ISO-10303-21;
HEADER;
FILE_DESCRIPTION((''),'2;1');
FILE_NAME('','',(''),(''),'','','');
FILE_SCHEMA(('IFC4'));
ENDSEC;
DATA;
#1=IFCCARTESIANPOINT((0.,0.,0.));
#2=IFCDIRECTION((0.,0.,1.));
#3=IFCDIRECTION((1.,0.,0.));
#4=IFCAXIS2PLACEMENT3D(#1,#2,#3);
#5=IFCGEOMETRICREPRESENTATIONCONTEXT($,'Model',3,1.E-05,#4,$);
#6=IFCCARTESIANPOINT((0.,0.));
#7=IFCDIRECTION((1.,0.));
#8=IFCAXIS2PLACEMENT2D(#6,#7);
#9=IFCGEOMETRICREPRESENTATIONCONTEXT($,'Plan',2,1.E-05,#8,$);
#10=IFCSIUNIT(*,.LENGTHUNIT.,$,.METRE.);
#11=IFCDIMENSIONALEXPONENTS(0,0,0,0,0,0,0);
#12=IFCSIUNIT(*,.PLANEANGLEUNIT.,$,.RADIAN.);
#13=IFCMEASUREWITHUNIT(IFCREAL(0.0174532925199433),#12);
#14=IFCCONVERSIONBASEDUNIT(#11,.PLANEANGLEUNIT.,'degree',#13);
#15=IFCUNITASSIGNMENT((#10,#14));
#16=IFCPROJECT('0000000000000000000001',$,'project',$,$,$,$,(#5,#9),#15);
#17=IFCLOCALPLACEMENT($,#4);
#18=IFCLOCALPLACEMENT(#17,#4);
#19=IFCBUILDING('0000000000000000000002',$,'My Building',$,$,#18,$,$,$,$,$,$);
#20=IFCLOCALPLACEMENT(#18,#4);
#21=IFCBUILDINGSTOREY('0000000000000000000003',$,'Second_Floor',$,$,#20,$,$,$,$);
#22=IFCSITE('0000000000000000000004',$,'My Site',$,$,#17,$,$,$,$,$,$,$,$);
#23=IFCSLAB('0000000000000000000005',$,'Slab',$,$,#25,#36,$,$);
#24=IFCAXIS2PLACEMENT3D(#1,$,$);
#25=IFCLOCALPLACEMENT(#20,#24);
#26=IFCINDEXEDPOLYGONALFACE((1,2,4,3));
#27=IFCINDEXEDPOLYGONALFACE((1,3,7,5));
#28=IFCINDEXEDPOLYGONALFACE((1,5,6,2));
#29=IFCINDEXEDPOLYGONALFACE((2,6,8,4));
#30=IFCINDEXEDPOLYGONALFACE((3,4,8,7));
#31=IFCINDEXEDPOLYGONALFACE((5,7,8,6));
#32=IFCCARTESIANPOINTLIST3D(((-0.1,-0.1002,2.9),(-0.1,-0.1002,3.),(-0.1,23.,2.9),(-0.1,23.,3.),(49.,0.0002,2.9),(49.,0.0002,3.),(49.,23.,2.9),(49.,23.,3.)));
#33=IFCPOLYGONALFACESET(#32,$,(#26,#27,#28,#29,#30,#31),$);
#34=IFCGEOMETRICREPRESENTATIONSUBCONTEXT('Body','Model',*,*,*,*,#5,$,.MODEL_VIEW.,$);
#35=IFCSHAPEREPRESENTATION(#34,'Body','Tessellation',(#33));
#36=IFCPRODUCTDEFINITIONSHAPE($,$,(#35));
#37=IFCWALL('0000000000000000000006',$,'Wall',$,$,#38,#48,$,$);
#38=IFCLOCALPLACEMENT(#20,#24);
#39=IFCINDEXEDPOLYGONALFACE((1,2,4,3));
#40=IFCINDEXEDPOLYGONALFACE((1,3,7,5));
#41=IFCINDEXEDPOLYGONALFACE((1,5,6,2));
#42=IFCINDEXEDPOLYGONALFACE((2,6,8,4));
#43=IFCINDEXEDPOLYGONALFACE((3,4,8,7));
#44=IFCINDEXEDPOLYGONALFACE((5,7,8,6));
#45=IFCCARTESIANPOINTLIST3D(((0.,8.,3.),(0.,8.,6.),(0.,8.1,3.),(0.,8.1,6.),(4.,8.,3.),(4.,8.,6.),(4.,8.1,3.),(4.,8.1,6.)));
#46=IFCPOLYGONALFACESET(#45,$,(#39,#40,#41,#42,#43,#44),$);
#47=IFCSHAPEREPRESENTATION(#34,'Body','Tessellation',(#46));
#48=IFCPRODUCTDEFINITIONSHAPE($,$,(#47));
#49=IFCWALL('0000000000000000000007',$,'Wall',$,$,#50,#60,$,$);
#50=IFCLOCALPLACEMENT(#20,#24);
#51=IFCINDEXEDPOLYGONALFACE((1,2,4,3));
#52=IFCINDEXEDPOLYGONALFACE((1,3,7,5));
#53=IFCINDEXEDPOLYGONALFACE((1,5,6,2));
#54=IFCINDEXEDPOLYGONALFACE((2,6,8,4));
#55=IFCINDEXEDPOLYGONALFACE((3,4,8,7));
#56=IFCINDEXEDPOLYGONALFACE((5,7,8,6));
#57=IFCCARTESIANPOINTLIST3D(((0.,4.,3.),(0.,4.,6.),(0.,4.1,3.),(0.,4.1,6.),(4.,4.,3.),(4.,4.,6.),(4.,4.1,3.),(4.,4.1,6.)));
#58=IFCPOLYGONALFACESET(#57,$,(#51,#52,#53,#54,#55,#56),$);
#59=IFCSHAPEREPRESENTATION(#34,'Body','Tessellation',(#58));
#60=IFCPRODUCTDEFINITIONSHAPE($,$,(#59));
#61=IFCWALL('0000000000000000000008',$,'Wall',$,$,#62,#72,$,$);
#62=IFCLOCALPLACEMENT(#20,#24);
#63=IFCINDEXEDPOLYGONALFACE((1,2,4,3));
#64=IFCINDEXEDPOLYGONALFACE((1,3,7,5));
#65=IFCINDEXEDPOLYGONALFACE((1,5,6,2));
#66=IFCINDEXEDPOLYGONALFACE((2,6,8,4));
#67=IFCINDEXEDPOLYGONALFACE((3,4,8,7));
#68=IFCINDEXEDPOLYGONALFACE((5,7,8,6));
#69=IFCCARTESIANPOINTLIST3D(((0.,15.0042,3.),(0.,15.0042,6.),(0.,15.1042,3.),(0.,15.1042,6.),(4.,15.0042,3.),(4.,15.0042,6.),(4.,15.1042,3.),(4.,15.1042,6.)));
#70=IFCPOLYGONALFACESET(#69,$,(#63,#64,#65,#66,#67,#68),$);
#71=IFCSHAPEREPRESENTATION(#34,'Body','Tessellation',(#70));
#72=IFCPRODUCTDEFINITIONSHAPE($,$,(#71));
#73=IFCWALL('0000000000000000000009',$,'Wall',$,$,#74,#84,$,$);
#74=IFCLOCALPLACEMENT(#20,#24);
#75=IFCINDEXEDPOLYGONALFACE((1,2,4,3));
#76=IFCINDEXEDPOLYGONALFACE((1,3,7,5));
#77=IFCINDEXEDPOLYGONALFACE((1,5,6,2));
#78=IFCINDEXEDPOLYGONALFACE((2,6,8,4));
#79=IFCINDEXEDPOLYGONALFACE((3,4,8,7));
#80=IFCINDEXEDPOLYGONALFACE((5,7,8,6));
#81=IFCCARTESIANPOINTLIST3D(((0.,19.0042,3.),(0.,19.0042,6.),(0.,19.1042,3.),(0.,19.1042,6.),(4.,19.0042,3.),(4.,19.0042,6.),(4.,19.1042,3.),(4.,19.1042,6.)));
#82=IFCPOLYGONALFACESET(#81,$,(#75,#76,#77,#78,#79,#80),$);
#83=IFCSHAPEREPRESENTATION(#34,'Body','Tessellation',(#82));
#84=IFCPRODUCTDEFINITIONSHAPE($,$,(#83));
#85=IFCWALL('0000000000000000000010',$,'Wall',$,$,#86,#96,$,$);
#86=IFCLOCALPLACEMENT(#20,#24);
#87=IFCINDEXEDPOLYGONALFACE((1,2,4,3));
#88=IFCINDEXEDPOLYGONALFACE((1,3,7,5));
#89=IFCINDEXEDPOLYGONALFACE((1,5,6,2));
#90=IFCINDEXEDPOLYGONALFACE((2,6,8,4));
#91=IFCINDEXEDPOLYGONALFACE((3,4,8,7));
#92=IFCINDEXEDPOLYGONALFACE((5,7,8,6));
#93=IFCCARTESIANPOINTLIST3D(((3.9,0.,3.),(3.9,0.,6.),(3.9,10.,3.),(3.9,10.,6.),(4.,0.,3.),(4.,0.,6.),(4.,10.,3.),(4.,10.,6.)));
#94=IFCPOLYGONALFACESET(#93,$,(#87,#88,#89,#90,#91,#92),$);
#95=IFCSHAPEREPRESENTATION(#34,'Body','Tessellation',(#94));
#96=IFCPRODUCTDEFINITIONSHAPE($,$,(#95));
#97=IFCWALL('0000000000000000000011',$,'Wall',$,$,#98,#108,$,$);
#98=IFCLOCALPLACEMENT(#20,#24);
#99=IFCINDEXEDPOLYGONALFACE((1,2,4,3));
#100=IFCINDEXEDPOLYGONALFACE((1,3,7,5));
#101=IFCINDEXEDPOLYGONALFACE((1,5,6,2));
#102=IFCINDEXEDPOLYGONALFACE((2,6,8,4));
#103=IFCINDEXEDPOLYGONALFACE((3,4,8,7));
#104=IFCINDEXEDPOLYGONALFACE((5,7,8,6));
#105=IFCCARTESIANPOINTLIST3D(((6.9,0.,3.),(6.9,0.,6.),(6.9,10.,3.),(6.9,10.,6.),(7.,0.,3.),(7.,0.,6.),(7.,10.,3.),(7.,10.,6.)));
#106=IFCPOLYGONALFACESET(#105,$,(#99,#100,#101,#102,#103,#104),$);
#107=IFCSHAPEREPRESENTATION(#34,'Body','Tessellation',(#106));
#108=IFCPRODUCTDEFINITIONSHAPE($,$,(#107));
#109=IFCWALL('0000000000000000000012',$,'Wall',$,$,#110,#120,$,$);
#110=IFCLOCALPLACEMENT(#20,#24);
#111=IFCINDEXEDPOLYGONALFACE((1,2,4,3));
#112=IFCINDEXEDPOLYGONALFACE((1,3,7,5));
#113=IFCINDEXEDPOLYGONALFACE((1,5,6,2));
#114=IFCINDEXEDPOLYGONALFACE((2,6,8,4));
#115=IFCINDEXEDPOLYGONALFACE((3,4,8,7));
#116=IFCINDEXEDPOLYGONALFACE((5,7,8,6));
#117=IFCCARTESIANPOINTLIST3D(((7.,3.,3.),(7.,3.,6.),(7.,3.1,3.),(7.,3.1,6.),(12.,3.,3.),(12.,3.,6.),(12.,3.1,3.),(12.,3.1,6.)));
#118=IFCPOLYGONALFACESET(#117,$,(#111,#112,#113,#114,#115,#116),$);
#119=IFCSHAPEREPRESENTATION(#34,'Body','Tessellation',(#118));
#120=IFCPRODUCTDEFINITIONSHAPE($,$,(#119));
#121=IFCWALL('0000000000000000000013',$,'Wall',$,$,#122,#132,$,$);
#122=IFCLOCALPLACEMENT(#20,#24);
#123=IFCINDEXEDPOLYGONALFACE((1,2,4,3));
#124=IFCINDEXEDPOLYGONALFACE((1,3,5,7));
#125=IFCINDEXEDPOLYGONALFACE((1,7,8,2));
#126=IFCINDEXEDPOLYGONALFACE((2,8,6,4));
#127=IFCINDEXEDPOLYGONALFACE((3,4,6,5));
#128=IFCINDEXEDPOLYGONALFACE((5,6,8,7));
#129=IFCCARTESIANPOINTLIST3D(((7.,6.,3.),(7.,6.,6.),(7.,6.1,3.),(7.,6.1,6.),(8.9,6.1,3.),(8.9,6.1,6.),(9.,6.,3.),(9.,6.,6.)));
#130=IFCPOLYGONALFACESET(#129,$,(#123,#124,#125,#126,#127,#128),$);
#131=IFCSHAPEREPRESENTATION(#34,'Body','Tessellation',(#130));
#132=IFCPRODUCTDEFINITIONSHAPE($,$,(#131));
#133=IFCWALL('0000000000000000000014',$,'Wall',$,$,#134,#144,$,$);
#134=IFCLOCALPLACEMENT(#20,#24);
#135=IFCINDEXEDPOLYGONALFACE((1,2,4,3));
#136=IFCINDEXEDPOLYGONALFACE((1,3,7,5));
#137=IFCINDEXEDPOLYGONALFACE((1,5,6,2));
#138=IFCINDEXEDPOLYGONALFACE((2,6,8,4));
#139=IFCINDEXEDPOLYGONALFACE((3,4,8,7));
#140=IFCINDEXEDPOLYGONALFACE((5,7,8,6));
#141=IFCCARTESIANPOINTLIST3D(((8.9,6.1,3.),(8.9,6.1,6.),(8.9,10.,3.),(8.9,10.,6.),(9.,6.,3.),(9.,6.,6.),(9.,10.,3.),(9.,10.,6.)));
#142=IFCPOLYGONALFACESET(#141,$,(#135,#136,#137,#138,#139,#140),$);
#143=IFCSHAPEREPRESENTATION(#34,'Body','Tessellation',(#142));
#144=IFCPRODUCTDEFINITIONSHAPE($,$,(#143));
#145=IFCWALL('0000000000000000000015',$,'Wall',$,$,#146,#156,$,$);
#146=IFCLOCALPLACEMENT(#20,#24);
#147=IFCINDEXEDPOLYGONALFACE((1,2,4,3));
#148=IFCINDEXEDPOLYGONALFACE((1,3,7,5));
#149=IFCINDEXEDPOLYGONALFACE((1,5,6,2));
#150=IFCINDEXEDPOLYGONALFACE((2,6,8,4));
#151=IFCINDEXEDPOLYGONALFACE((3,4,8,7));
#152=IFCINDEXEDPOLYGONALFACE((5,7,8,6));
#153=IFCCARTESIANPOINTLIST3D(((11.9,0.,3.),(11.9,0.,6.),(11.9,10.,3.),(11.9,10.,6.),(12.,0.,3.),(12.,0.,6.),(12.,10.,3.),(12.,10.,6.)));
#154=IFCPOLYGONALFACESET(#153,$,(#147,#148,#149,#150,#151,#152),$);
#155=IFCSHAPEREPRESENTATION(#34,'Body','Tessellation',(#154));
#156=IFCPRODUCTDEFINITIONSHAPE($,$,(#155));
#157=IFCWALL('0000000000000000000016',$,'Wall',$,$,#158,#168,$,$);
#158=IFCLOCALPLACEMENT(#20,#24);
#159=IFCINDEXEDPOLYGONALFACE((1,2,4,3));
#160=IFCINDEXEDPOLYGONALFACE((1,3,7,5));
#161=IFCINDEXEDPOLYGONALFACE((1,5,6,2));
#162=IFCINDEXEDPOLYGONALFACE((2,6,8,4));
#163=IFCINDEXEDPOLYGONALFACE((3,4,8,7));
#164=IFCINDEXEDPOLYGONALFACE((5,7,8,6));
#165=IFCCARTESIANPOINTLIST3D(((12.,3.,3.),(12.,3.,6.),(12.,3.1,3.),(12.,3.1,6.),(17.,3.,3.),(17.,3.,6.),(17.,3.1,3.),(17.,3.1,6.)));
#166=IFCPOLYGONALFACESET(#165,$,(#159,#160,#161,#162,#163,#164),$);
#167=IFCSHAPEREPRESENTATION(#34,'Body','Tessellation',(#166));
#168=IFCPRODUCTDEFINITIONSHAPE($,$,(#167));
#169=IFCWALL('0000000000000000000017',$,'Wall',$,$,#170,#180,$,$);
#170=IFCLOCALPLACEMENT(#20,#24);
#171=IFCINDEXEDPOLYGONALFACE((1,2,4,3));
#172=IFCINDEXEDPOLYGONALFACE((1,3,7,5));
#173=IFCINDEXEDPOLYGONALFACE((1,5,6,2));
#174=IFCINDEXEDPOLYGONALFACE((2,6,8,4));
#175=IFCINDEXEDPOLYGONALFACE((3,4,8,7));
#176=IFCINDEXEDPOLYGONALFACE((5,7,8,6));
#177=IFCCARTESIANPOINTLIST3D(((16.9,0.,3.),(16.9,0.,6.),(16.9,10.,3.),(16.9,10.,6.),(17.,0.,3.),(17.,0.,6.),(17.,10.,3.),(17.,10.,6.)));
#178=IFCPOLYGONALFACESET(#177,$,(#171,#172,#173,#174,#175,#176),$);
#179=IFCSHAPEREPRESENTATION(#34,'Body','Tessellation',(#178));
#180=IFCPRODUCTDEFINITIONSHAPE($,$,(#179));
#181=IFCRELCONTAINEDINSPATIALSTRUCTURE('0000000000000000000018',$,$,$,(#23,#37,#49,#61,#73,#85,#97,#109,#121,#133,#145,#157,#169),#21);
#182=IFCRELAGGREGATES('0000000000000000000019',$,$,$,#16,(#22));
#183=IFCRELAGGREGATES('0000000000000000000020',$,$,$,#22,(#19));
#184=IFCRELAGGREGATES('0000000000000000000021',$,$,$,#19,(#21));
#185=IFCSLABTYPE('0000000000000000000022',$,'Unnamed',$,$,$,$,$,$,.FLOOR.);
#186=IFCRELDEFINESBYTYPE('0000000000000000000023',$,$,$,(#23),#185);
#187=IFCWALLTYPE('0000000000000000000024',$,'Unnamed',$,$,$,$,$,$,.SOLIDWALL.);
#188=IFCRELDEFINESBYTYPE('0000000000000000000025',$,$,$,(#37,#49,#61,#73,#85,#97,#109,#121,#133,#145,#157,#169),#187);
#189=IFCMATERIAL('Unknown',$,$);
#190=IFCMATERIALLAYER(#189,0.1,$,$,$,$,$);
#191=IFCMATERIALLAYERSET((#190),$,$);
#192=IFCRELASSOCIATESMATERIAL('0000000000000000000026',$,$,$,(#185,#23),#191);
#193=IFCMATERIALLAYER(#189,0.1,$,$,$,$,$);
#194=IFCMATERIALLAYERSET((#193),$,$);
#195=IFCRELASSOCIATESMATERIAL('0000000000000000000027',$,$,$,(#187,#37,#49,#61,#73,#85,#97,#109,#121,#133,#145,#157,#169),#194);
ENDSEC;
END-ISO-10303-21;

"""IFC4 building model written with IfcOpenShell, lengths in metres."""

from ifc_helpers import new_model, entity, si_unit, converted_unit, frame, origin_with_axes, origin_2d_with_axis, place, context, subcontext, project, spatial, line, indexed_curve, outline, extrude, material, layer, layer_set, layer_usage, type_object, element, save


model = new_model("IFC4")

# Units and contexts
model_context = context("Model", 3, precision=1e-05, world=origin_with_axes())
plan_context = context("Plan", 2, precision=1e-05, world=origin_2d_with_axis())
body_context = subcontext(model_context, "Body", "Model", "MODEL_VIEW")
ifc_project = project(units=[si_unit("LENGTHUNIT", "METRE"), converted_unit("PLANEANGLEUNIT", "degree", entity("IfcReal", 0.0174532925199433), si_unit("PLANEANGLEUNIT", "RADIAN"), dimensions=[0, 0, 0, 0, 0, 0, 0])], contexts=[model_context, plan_context])

# Site, building, storey
site_placement = place(None, origin_with_axes())
site = spatial("IfcSite", under=ifc_project, at=site_placement, Name="My Site")
building_placement = place(site_placement, origin_with_axes())
building = spatial("IfcBuilding", under=site, at=building_placement, Name="My Building")
storey_placement = place(building_placement, origin_with_axes())
storey = spatial("IfcBuildingStorey", under=building, at=storey_placement, Name="Second_Floor")

# Slab
ifc_material = material(Name="Unknown")
ifc_layer_1 = layer(ifc_material, 0.1)
ifc_layer_set_1 = layer_set([ifc_layer_1])
ifc_layer_usage_1 = layer_usage(ifc_layer_set_1, "AXIS3", "POSITIVE", -0.1)
slab_type = type_object("IfcSlabType", Name="Unnamed", PredefinedType="FLOOR", material=ifc_layer_set_1)
slab_placement = place(storey_placement, frame((-0.1, 23.0, 3.0), z_axis=(0.0, 0.0, 1.0), x_axis=(1.0, 0.0, 0.0)))
element("IfcSlab", 1, at=slab_placement, inside=storey, type_object=slab_type, material=ifc_layer_usage_1, Name="Slab", context=body_context, shape_type="SweptSolid", body=[
    extrude(outline(indexed_curve([(0.0, -23.1002), (49.1, -22.9998), (49.1, 0.0), (0.0, 0.0), (0.0, -23.1002)])), frame((0.0, 0.0, -0.1), z_axis=(0.0, 0.0, 1.0), x_axis=(1.0, 0.0, 0.0)), (0.0, 0.0, 1.0), 0.1),
])

# Walls
ifc_layer_2 = layer(ifc_material, 0.1)
ifc_layer_set_2 = layer_set([ifc_layer_2])
ifc_layer_usage_2 = layer_usage(ifc_layer_set_2, "AXIS2", "POSITIVE", 0.0)
wall_type = type_object("IfcWallType", Name="Unnamed", PredefinedType="SOLIDWALL", material=ifc_layer_set_2)
wall_1_placement = place(storey_placement, frame((0.0, 8.0, 3.0), z_axis=(0.0, 0.0, 1.0), x_axis=(1.0, 0.0, 0.0)))
element("IfcWall", 2, at=wall_1_placement, inside=storey, type_object=wall_type, material=ifc_layer_usage_2, Name="Wall", context=body_context, shape_type="SweptSolid", body=[
    extrude(outline(indexed_curve([(0.0, 0.0), (0.0, 0.1), (4.0, 0.1), (4.0, 0.0)], segments=[line(1, 2, 3, 4, 1)])), origin_with_axes(), (0.0, 0.0, 1.0), 3.0),
])
ifc_layer_usage_3 = layer_usage(ifc_layer_set_2, "AXIS2", "POSITIVE", 0.0)
wall_2_placement = place(storey_placement, frame((0.0, 4.0, 3.0), z_axis=(0.0, 0.0, 1.0), x_axis=(1.0, 0.0, 0.0)))
element("IfcWall", 3, at=wall_2_placement, inside=storey, type_object=wall_type, material=ifc_layer_usage_3, Name="Wall", context=body_context, shape_type="SweptSolid", body=[
    extrude(outline(indexed_curve([(0.0, 0.0), (0.0, 0.1), (4.0, 0.1), (4.0, 0.0)], segments=[line(1, 2, 3, 4, 1)])), origin_with_axes(), (0.0, 0.0, 1.0), 3.0),
])
ifc_layer_usage_4 = layer_usage(ifc_layer_set_2, "AXIS2", "POSITIVE", 0.0)
wall_3_placement = place(storey_placement, frame((0.0, 15.0042, 3.0), z_axis=(0.0, 0.0, 1.0), x_axis=(1.0, 0.0, 0.0)))
element("IfcWall", 4, at=wall_3_placement, inside=storey, type_object=wall_type, material=ifc_layer_usage_4, Name="Wall", context=body_context, shape_type="SweptSolid", body=[
    extrude(outline(indexed_curve([(0.0, 0.0), (0.0, 0.1), (4.0, 0.1), (4.0, 0.0)], segments=[line(1, 2, 3, 4, 1)])), origin_with_axes(), (0.0, 0.0, 1.0), 3.0),
])
ifc_layer_usage_5 = layer_usage(ifc_layer_set_2, "AXIS2", "POSITIVE", 0.0)
wall_4_placement = place(storey_placement, frame((0.0, 19.0042, 3.0), z_axis=(0.0, 0.0, 1.0), x_axis=(1.0, 0.0, 0.0)))
element("IfcWall", 5, at=wall_4_placement, inside=storey, type_object=wall_type, material=ifc_layer_usage_5, Name="Wall", context=body_context, shape_type="SweptSolid", body=[
    extrude(outline(indexed_curve([(0.0, 0.0), (0.0, 0.1), (4.0, 0.1), (4.0, 0.0)], segments=[line(1, 2, 3, 4, 1)])), origin_with_axes(), (0.0, 0.0, 1.0), 3.0),
])
ifc_layer_usage_6 = layer_usage(ifc_layer_set_2, "AXIS2", "POSITIVE", 0.0)
wall_5_placement = place(storey_placement, frame((3.9, 10.0, 3.0), z_axis=(0.0, 0.0, 1.0), x_axis=(0.0, -1.0, 0.0)))
element("IfcWall", 6, at=wall_5_placement, inside=storey, type_object=wall_type, material=ifc_layer_usage_6, Name="Wall", context=body_context, shape_type="SweptSolid", body=[
    extrude(outline(indexed_curve([(0.0, 0.0), (0.0, 0.1), (10.0, 0.1), (10.0, 0.0)], segments=[line(1, 2, 3, 4, 1)])), origin_with_axes(), (0.0, 0.0, 1.0), 3.0),
])
ifc_layer_usage_7 = layer_usage(ifc_layer_set_2, "AXIS2", "POSITIVE", 0.0)
wall_6_placement = place(storey_placement, frame((6.9, 10.0, 3.0), z_axis=(0.0, 0.0, 1.0), x_axis=(0.0, -1.0, 0.0)))
element("IfcWall", 7, at=wall_6_placement, inside=storey, type_object=wall_type, material=ifc_layer_usage_7, Name="Wall", context=body_context, shape_type="SweptSolid", body=[
    extrude(outline(indexed_curve([(0.0, 0.0), (0.0, 0.1), (10.0, 0.1), (10.0, 0.0)], segments=[line(1, 2, 3, 4, 1)])), origin_with_axes(), (0.0, 0.0, 1.0), 3.0),
])
ifc_layer_usage_8 = layer_usage(ifc_layer_set_2, "AXIS2", "POSITIVE", 0.0)
wall_7_placement = place(storey_placement, frame((7.0, 3.0, 3.0), z_axis=(0.0, 0.0, 1.0), x_axis=(1.0, 0.0, 0.0)))
element("IfcWall", 8, at=wall_7_placement, inside=storey, type_object=wall_type, material=ifc_layer_usage_8, Name="Wall", context=body_context, shape_type="SweptSolid", body=[
    extrude(outline(indexed_curve([(0.0, 0.0), (0.0, 0.1), (5.0, 0.1), (5.0, 0.0)], segments=[line(1, 2, 3, 4, 1)])), origin_with_axes(), (0.0, 0.0, 1.0), 3.0),
])
ifc_layer_usage_9 = layer_usage(ifc_layer_set_2, "AXIS2", "POSITIVE", 0.0)
wall_8_placement = place(storey_placement, frame((7.0, 6.0, 3.0), z_axis=(0.0, 0.0, 1.0), x_axis=(1.0, 0.0, 0.0)))
element("IfcWall", 9, at=wall_8_placement, inside=storey, type_object=wall_type, material=ifc_layer_usage_9, Name="Wall", context=body_context, shape_type="SweptSolid", body=[
    extrude(outline(indexed_curve([(0.0, 0.0), (0.0, 0.1), (1.9, 0.1), (2.0, 0.0)], segments=[line(1, 2, 3, 4, 1)])), origin_with_axes(), (0.0, 0.0, 1.0), 3.0),
])
ifc_layer_usage_10 = layer_usage(ifc_layer_set_2, "AXIS2", "POSITIVE", 0.0)
wall_9_placement = place(storey_placement, frame((9.0, 6.0, 3.0), z_axis=(0.0, 0.0, 1.0), x_axis=(0.0, 1.0, 0.0)))
element("IfcWall", 10, at=wall_9_placement, inside=storey, type_object=wall_type, material=ifc_layer_usage_10, Name="Wall", context=body_context, shape_type="SweptSolid", body=[
    extrude(outline(indexed_curve([(0.0, 0.0), (0.1, 0.1), (4.0, 0.1), (4.0, 0.0)], segments=[line(1, 2, 3, 4, 1)])), origin_with_axes(), (0.0, 0.0, 1.0), 3.0),
])
ifc_layer_usage_11 = layer_usage(ifc_layer_set_2, "AXIS2", "POSITIVE", 0.0)
wall_10_placement = place(storey_placement, frame((11.9, 10.0, 3.0), z_axis=(0.0, 0.0, 1.0), x_axis=(0.0, -1.0, 0.0)))
element("IfcWall", 11, at=wall_10_placement, inside=storey, type_object=wall_type, material=ifc_layer_usage_11, Name="Wall", context=body_context, shape_type="SweptSolid", body=[
    extrude(outline(indexed_curve([(0.0, 0.0), (0.0, 0.1), (10.0, 0.1), (10.0, 0.0)], segments=[line(1, 2, 3, 4, 1)])), origin_with_axes(), (0.0, 0.0, 1.0), 3.0),
])
ifc_layer_usage_12 = layer_usage(ifc_layer_set_2, "AXIS2", "POSITIVE", 0.0)
wall_11_placement = place(storey_placement, frame((12.0, 3.0, 3.0), z_axis=(0.0, 0.0, 1.0), x_axis=(1.0, 0.0, 0.0)))
element("IfcWall", 12, at=wall_11_placement, inside=storey, type_object=wall_type, material=ifc_layer_usage_12, Name="Wall", context=body_context, shape_type="SweptSolid", body=[
    extrude(outline(indexed_curve([(0.0, 0.0), (0.0, 0.1), (5.0, 0.1), (5.0, 0.0)], segments=[line(1, 2, 3, 4, 1)])), origin_with_axes(), (0.0, 0.0, 1.0), 3.0),
])
ifc_layer_usage_13 = layer_usage(ifc_layer_set_2, "AXIS2", "POSITIVE", 0.0)
wall_12_placement = place(storey_placement, frame((16.9, 10.0, 3.0), z_axis=(0.0, 0.0, 1.0), x_axis=(0.0, -1.0, 0.0)))
element("IfcWall", 13, at=wall_12_placement, inside=storey, type_object=wall_type, material=ifc_layer_usage_13, Name="Wall", context=body_context, shape_type="SweptSolid", body=[
    extrude(outline(indexed_curve([(0.0, 0.0), (0.0, 0.1), (10.0, 0.1), (10.0, 0.0)], segments=[line(1, 2, 3, 4, 1)])), origin_with_axes(), (0.0, 0.0, 1.0), 3.0),
])

save(model, "model.ifc")
